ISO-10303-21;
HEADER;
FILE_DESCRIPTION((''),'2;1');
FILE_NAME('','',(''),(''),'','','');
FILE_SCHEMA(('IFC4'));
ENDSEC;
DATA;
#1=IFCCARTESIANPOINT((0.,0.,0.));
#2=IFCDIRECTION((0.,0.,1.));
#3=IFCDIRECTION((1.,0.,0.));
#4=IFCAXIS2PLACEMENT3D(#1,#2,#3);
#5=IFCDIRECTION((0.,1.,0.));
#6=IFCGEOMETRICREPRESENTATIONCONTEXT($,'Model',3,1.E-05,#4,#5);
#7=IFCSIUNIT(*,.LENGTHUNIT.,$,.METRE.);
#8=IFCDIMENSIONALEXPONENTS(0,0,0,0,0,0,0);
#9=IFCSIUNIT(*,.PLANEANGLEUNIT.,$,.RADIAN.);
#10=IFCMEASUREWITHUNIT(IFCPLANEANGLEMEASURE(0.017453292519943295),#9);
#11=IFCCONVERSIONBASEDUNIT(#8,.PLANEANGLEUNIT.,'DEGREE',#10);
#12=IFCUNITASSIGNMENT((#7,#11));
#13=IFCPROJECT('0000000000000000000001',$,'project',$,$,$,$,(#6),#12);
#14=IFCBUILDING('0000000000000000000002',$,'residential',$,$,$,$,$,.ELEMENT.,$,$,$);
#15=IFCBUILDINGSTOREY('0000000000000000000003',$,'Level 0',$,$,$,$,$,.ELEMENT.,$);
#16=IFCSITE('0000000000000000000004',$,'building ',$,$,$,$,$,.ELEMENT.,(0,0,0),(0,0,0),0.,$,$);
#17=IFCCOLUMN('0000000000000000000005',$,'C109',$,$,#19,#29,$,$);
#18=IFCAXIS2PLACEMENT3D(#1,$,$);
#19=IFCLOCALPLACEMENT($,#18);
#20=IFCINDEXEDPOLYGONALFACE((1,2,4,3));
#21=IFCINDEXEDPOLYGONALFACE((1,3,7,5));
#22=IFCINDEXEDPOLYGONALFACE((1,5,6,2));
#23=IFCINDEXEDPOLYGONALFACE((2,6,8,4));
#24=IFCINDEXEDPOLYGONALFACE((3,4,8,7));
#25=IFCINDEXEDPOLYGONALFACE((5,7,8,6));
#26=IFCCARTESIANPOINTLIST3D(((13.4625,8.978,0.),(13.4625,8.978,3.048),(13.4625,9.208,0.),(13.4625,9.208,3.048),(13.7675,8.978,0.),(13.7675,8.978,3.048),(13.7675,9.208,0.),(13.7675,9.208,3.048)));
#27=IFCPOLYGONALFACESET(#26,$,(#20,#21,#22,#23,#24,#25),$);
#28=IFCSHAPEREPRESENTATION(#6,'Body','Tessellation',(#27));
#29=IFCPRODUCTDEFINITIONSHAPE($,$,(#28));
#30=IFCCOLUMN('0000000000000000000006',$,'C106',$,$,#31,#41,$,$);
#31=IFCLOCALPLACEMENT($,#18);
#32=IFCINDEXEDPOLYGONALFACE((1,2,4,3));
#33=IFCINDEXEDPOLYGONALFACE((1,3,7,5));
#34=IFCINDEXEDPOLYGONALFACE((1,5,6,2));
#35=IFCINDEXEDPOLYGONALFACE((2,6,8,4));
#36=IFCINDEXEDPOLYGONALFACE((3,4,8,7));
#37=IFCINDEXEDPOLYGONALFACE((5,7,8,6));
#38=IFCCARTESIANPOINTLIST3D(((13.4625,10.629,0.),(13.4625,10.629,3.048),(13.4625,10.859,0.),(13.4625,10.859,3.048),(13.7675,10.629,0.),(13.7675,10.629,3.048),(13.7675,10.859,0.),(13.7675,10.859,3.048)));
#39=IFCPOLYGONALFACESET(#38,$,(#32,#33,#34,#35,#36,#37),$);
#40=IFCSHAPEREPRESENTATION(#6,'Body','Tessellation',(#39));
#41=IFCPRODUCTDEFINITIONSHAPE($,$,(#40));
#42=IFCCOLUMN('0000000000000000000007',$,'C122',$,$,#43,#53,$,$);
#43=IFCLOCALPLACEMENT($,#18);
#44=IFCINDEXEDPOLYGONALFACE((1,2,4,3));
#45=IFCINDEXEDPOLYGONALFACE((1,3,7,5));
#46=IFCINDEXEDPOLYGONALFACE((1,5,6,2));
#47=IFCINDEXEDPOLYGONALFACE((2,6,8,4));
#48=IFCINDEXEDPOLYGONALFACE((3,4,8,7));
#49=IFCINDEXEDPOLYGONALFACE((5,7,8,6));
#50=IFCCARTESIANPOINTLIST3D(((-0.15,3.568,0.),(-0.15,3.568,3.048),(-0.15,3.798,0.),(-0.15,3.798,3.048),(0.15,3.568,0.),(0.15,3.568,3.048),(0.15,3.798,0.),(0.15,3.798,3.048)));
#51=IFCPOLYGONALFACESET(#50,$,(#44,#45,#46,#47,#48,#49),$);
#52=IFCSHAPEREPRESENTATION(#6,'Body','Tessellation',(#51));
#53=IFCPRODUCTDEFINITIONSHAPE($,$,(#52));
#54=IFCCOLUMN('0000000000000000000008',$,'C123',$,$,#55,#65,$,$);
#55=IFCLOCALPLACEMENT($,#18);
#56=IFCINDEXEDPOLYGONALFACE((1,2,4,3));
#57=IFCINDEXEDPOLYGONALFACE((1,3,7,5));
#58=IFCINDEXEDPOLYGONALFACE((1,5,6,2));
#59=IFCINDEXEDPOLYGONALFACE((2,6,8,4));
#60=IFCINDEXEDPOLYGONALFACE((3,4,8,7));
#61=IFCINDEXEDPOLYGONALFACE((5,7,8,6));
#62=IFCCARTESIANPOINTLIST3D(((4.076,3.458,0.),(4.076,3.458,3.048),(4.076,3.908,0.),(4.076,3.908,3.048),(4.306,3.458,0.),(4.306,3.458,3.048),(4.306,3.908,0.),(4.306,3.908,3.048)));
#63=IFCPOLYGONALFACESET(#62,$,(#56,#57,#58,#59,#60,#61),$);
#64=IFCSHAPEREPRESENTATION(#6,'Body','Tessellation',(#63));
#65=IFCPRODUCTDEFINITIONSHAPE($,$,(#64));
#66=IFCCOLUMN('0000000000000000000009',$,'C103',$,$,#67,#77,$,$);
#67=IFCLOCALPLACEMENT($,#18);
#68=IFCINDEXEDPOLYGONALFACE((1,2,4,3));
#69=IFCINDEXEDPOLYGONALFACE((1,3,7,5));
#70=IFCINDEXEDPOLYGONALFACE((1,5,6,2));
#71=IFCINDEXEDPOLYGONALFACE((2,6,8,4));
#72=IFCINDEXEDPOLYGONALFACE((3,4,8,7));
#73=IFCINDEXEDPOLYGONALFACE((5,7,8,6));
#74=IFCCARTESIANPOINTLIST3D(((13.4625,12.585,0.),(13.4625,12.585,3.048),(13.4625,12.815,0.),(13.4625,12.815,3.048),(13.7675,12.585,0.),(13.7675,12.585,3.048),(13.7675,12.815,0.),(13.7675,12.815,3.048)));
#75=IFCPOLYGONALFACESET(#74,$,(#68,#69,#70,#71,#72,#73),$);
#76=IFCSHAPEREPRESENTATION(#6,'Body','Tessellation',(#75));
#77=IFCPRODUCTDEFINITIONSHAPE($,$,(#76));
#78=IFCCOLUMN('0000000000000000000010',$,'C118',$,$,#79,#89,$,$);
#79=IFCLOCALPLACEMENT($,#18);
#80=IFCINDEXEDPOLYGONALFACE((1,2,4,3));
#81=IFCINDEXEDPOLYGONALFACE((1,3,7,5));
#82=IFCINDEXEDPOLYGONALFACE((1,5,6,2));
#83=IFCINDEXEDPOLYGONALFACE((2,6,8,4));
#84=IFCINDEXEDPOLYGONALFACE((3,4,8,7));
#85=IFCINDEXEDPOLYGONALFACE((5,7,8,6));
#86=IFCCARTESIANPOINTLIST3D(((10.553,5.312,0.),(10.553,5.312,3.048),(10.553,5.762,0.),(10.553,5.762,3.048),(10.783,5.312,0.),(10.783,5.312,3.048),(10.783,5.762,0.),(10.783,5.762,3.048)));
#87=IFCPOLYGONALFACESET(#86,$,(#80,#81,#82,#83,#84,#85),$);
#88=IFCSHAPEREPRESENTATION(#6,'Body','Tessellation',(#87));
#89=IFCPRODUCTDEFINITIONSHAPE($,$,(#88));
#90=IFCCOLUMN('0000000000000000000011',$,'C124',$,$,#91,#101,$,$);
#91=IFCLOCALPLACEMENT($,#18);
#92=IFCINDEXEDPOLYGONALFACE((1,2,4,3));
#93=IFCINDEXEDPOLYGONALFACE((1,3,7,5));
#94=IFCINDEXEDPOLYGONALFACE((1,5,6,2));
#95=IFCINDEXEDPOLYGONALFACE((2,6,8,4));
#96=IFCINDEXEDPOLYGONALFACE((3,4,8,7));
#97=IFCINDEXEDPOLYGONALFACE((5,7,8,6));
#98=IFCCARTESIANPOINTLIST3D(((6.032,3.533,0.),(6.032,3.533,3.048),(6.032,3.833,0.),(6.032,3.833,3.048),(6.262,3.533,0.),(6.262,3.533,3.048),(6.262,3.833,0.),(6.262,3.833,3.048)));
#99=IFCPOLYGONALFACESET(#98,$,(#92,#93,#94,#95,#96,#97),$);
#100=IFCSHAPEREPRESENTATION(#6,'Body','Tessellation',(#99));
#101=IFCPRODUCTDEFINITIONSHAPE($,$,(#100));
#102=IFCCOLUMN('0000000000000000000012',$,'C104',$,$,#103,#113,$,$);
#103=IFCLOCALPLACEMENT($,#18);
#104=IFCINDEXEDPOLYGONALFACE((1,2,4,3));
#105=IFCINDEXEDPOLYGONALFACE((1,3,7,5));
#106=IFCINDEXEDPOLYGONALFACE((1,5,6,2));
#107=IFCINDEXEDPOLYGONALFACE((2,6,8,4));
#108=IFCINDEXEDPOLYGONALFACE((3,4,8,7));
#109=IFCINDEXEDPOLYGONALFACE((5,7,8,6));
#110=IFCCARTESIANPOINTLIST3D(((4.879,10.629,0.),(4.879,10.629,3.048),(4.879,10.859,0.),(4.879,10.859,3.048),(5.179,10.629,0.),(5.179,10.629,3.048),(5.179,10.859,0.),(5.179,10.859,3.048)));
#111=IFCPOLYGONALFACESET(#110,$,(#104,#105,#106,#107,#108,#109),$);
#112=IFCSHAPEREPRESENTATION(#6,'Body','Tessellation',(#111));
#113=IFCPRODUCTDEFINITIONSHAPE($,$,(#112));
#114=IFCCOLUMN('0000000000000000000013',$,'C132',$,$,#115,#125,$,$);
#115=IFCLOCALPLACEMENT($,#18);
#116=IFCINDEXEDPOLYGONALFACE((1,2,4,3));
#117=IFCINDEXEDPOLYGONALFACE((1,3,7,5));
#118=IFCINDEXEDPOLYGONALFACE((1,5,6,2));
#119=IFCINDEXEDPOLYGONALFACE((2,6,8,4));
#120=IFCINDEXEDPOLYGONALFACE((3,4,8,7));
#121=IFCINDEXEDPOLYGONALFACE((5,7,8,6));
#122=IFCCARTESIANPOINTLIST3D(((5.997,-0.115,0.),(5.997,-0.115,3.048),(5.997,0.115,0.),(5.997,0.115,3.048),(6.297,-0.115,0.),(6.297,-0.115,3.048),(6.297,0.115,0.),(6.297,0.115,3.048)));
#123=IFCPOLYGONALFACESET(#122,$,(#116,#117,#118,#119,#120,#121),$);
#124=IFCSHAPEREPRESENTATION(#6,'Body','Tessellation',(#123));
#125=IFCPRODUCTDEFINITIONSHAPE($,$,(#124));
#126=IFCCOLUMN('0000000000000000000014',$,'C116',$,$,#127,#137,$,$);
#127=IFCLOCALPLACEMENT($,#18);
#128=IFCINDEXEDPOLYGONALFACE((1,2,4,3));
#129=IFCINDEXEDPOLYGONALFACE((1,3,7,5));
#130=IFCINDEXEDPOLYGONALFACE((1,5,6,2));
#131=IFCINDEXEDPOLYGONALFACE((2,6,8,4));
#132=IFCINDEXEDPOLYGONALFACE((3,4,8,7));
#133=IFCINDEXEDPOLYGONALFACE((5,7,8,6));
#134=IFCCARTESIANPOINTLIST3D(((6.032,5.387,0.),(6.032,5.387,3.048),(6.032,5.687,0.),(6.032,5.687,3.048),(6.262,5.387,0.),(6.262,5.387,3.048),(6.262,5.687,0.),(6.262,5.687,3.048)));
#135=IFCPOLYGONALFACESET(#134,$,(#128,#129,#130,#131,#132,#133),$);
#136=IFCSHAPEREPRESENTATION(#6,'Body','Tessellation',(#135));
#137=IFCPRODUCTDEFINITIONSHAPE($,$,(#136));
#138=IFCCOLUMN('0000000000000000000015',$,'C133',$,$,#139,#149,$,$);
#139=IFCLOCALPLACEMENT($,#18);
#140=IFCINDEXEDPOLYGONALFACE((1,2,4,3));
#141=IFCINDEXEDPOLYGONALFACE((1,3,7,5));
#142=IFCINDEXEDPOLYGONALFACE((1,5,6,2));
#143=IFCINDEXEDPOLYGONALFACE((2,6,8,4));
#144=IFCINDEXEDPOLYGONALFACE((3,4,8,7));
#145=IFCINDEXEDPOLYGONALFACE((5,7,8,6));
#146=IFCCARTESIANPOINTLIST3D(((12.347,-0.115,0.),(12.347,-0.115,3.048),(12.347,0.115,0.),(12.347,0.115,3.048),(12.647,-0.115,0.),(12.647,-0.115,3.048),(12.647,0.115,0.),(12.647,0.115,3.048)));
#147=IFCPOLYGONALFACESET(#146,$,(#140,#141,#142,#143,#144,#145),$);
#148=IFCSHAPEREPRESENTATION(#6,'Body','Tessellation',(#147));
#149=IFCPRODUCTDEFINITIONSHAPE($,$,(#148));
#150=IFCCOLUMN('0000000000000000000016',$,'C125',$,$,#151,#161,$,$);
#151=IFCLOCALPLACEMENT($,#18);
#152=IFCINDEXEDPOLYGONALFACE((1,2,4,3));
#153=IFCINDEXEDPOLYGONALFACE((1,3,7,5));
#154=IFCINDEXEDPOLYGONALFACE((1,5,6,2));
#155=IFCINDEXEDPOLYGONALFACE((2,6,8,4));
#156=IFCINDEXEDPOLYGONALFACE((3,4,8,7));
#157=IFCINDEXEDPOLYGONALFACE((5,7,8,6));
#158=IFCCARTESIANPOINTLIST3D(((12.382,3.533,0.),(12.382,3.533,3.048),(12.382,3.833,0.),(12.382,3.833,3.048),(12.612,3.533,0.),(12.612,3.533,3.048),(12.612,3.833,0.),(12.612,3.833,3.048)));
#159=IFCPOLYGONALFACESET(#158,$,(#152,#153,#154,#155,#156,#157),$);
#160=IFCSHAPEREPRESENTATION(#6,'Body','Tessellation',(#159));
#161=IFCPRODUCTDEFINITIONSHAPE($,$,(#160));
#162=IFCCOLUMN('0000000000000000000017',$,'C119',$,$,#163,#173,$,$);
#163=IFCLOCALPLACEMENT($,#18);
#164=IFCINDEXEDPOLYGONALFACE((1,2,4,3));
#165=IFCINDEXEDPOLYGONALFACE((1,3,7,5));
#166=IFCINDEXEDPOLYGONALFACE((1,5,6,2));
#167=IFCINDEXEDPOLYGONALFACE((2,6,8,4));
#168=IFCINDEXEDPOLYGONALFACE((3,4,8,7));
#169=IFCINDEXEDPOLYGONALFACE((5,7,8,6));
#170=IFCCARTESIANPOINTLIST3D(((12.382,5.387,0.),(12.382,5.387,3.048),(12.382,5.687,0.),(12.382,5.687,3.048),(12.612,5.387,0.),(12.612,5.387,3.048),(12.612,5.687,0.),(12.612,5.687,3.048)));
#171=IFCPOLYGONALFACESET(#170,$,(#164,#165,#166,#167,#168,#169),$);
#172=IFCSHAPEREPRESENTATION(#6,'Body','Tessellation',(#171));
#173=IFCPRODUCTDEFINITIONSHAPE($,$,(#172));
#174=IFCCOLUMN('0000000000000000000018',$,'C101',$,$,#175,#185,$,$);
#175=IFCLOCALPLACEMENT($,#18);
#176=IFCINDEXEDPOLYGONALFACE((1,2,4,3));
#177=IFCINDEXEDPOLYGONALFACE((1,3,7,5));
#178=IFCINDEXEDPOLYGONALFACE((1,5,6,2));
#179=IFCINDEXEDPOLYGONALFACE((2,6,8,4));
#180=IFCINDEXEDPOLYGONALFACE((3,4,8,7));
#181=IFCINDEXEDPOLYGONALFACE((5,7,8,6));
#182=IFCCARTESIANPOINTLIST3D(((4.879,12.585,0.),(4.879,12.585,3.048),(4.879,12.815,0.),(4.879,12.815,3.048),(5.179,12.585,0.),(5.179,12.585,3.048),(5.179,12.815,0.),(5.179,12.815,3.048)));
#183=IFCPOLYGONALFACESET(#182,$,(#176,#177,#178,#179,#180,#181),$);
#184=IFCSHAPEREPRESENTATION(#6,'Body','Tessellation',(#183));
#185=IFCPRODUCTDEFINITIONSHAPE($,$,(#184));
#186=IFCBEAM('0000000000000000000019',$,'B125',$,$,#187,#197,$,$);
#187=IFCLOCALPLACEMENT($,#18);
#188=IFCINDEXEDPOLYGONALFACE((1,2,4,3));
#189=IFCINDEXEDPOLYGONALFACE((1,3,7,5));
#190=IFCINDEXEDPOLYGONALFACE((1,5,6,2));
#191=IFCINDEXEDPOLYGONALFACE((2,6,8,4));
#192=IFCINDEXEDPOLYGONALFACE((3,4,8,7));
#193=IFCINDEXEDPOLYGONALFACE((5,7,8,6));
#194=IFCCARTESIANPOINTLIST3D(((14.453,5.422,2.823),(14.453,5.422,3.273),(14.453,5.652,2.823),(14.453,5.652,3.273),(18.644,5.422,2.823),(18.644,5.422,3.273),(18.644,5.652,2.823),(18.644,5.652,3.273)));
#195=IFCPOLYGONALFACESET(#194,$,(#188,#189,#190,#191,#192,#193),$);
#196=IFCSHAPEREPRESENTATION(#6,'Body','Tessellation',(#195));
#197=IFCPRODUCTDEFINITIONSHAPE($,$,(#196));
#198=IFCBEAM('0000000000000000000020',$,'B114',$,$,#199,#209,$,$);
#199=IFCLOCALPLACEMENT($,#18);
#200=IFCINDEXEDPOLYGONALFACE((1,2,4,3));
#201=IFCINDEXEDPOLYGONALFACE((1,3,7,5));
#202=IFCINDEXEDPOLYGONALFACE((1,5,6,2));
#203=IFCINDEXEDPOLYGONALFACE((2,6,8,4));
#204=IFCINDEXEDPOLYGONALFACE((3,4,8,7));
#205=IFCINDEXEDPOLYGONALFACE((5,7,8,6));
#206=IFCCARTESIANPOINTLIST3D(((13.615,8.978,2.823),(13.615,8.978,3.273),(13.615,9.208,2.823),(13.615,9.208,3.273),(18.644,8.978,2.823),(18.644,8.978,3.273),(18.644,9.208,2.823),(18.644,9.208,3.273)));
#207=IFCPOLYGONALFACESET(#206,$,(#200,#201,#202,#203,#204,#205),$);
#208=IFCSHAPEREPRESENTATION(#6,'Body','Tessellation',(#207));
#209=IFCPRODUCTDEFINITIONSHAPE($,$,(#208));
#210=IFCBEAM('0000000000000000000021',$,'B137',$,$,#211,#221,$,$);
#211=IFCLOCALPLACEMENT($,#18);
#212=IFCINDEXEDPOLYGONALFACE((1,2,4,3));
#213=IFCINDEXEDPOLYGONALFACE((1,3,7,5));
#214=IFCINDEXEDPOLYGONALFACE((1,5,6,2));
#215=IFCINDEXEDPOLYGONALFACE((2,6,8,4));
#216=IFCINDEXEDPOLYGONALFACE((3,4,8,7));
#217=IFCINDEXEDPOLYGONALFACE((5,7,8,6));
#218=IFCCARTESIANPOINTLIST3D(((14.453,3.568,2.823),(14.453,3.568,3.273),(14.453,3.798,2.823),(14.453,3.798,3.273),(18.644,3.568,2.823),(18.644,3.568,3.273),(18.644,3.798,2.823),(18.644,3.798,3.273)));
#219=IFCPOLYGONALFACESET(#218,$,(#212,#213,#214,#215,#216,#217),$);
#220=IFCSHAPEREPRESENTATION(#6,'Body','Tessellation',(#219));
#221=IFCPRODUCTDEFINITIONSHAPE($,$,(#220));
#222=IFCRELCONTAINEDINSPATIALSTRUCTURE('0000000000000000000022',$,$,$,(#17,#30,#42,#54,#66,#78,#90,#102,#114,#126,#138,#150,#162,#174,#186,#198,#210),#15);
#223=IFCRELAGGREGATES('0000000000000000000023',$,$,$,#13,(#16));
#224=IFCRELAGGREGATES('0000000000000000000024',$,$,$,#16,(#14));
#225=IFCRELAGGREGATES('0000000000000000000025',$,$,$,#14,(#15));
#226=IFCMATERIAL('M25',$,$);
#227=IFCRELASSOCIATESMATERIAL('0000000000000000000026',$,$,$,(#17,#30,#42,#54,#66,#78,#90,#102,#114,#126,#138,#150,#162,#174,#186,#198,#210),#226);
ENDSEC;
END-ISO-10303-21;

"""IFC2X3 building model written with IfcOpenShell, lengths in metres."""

from ifc_helpers import new_model, entity, si_unit, converted_unit, direction, frame, frame_2d, origin_with_axes, place, context, project, spatial, rectangle, extrude, material, element, save


model = new_model("IFC2X3")

# Units and contexts
model_context = context("Model", 3, precision=1e-05, world=origin_with_axes(), true_north=direction((0.0, 1.0, 0.0)))
ifc_project = project(units=[si_unit("LENGTHUNIT", "METRE"), converted_unit("PLANEANGLEUNIT", "DEGREE", entity("IfcPlaneAngleMeasure", 0.017453292519943295), si_unit("PLANEANGLEUNIT", "RADIAN"), dimensions=[0, 0, 0, 0, 0, 0, 0])], contexts=[model_context])

# Site, building, storey
site = spatial("IfcSite", under=ifc_project, Name="building ", CompositionType="ELEMENT", RefLatitude=(0, 0, 0), RefLongitude=(0, 0, 0), RefElevation=0.0)
building = spatial("IfcBuilding", under=site, Name="residential", CompositionType="ELEMENT")
storey = spatial("IfcBuildingStorey", under=building, Name="Level 0", CompositionType="ELEMENT")

# Columns
ifc_material = material(Name="M25")
placement = place(None, origin_with_axes())
element("IfcColumn", 1, at=placement, inside=storey, material=ifc_material, Name="C109", context=model_context, shape_type="SweptSolid", body=[
    extrude(rectangle(XDim=0.305, YDim=0.23, at=frame_2d((0.0, 0.0), x_axis=(1.0, 0.0, 0.0))), frame((13.615, 9.093, 0.0), z_axis=(0.0, 0.0, 1.0), x_axis=(1.0, 0.0, 0.0)), (0.0, 0.0, 1.0), 3.048),
])
element("IfcColumn", 2, at=placement, inside=storey, material=ifc_material, Name="C106", context=model_context, shape_type="SweptSolid", body=[
    extrude(rectangle(XDim=0.305, YDim=0.23, at=frame_2d((0.0, 0.0), x_axis=(1.0, 0.0, 0.0))), frame((13.615, 10.744, 0.0), z_axis=(0.0, 0.0, 1.0), x_axis=(1.0, 0.0, 0.0)), (0.0, 0.0, 1.0), 3.048),
])
element("IfcColumn", 3, at=placement, inside=storey, material=ifc_material, Name="C122", context=model_context, shape_type="SweptSolid", body=[
    extrude(rectangle(XDim=0.3, YDim=0.23, at=frame_2d((0.0, 0.0), x_axis=(1.0, 0.0, 0.0))), frame((0.0, 3.683, 0.0), z_axis=(0.0, 0.0, 1.0), x_axis=(1.0, 0.0, 0.0)), (0.0, 0.0, 1.0), 3.048),
])
element("IfcColumn", 4, at=placement, inside=storey, material=ifc_material, Name="C123", context=model_context, shape_type="SweptSolid", body=[
    extrude(rectangle(XDim=0.23, YDim=0.45, at=frame_2d((0.0, 0.0), x_axis=(1.0, 0.0, 0.0))), frame((4.191, 3.683, 0.0), z_axis=(0.0, 0.0, 1.0), x_axis=(1.0, 0.0, 0.0)), (0.0, 0.0, 1.0), 3.048),
])
element("IfcColumn", 5, at=placement, inside=storey, material=ifc_material, Name="C103", context=model_context, shape_type="SweptSolid", body=[
    extrude(rectangle(XDim=0.305, YDim=0.23, at=frame_2d((0.0, 0.0), x_axis=(1.0, 0.0, 0.0))), frame((13.615, 12.7, 0.0), z_axis=(0.0, 0.0, 1.0), x_axis=(1.0, 0.0, 0.0)), (0.0, 0.0, 1.0), 3.048),
])
element("IfcColumn", 6, at=placement, inside=storey, material=ifc_material, Name="C118", context=model_context, shape_type="SweptSolid", body=[
    extrude(rectangle(XDim=0.23, YDim=0.45, at=frame_2d((0.0, 0.0), x_axis=(1.0, 0.0, 0.0))), frame((10.668, 5.537, 0.0), z_axis=(0.0, 0.0, 1.0), x_axis=(1.0, 0.0, 0.0)), (0.0, 0.0, 1.0), 3.048),
])
element("IfcColumn", 7, at=placement, inside=storey, material=ifc_material, Name="C124", context=model_context, shape_type="SweptSolid", body=[
    extrude(rectangle(XDim=0.23, YDim=0.3, at=frame_2d((0.0, 0.0), x_axis=(1.0, 0.0, 0.0))), frame((6.147, 3.683, 0.0), z_axis=(0.0, 0.0, 1.0), x_axis=(1.0, 0.0, 0.0)), (0.0, 0.0, 1.0), 3.048),
])
element("IfcColumn", 8, at=placement, inside=storey, material=ifc_material, Name="C104", context=model_context, shape_type="SweptSolid", body=[
    extrude(rectangle(XDim=0.3, YDim=0.23, at=frame_2d((0.0, 0.0), x_axis=(1.0, 0.0, 0.0))), frame((5.029, 10.744, 0.0), z_axis=(0.0, 0.0, 1.0), x_axis=(1.0, 0.0, 0.0)), (0.0, 0.0, 1.0), 3.048),
])
element("IfcColumn", 9, at=placement, inside=storey, material=ifc_material, Name="C132", context=model_context, shape_type="SweptSolid", body=[
    extrude(rectangle(XDim=0.3, YDim=0.23, at=frame_2d((0.0, 0.0), x_axis=(1.0, 0.0, 0.0))), frame((6.147, 0.0, 0.0), z_axis=(0.0, 0.0, 1.0), x_axis=(1.0, 0.0, 0.0)), (0.0, 0.0, 1.0), 3.048),
])
element("IfcColumn", 10, at=placement, inside=storey, material=ifc_material, Name="C116", context=model_context, shape_type="SweptSolid", body=[
    extrude(rectangle(XDim=0.23, YDim=0.3, at=frame_2d((0.0, 0.0), x_axis=(1.0, 0.0, 0.0))), frame((6.147, 5.537, 0.0), z_axis=(0.0, 0.0, 1.0), x_axis=(1.0, 0.0, 0.0)), (0.0, 0.0, 1.0), 3.048),
])
element("IfcColumn", 11, at=placement, inside=storey, material=ifc_material, Name="C133", context=model_context, shape_type="SweptSolid", body=[
    extrude(rectangle(XDim=0.3, YDim=0.23, at=frame_2d((0.0, 0.0), x_axis=(1.0, 0.0, 0.0))), frame((12.497, 0.0, 0.0), z_axis=(0.0, 0.0, 1.0), x_axis=(1.0, 0.0, 0.0)), (0.0, 0.0, 1.0), 3.048),
])
element("IfcColumn", 12, at=placement, inside=storey, material=ifc_material, Name="C125", context=model_context, shape_type="SweptSolid", body=[
    extrude(rectangle(XDim=0.23, YDim=0.3, at=frame_2d((0.0, 0.0), x_axis=(1.0, 0.0, 0.0))), frame((12.497, 3.683, 0.0), z_axis=(0.0, 0.0, 1.0), x_axis=(1.0, 0.0, 0.0)), (0.0, 0.0, 1.0), 3.048),
])
element("IfcColumn", 13, at=placement, inside=storey, material=ifc_material, Name="C119", context=model_context, shape_type="SweptSolid", body=[
    extrude(rectangle(XDim=0.23, YDim=0.3, at=frame_2d((0.0, 0.0), x_axis=(1.0, 0.0, 0.0))), frame((12.497, 5.537, 0.0), z_axis=(0.0, 0.0, 1.0), x_axis=(1.0, 0.0, 0.0)), (0.0, 0.0, 1.0), 3.048),
])
element("IfcColumn", 14, at=placement, inside=storey, material=ifc_material, Name="C101", context=model_context, shape_type="SweptSolid", body=[
    extrude(rectangle(XDim=0.3, YDim=0.23, at=frame_2d((0.0, 0.0), x_axis=(1.0, 0.0, 0.0))), frame((5.029, 12.7, 0.0), z_axis=(0.0, 0.0, 1.0), x_axis=(1.0, 0.0, 0.0)), (0.0, 0.0, 1.0), 3.048),
])

# Beams
element("IfcBeam", 15, at=placement, inside=storey, material=ifc_material, Name="B125", context=model_context, shape_type="SweptSolid", body=[
    extrude(rectangle(XDim=0.23, YDim=0.45, at=frame_2d((0.0, 0.0), x_axis=(0.0, 1.0, 0.0))), frame((18.644, 5.537, 3.048), z_axis=(-1.0, 0.0, 0.0), x_axis=(0.0, 0.0, -1.0)), (0.0, 0.0, 1.0), 4.191),
])
element("IfcBeam", 16, at=placement, inside=storey, material=ifc_material, Name="B114", context=model_context, shape_type="SweptSolid", body=[
    extrude(rectangle(XDim=0.23, YDim=0.45, at=frame_2d((0.0, 0.0), x_axis=(0.0, 1.0, 0.0))), frame((18.644, 9.093, 3.048), z_axis=(-1.0, 0.0, 0.0), x_axis=(0.0, 0.0, -1.0)), (0.0, 0.0, 1.0), 5.029),
])
element("IfcBeam", 17, at=placement, inside=storey, material=ifc_material, Name="B137", context=model_context, shape_type="SweptSolid", body=[
    extrude(rectangle(XDim=0.23, YDim=0.45, at=frame_2d((0.0, 0.0), x_axis=(0.0, 1.0, 0.0))), frame((18.644, 3.683, 3.048), z_axis=(-1.0, 0.0, 0.0), x_axis=(0.0, 0.0, -1.0)), (0.0, 0.0, 1.0), 4.191),
])

save(model, "model.ifc")
